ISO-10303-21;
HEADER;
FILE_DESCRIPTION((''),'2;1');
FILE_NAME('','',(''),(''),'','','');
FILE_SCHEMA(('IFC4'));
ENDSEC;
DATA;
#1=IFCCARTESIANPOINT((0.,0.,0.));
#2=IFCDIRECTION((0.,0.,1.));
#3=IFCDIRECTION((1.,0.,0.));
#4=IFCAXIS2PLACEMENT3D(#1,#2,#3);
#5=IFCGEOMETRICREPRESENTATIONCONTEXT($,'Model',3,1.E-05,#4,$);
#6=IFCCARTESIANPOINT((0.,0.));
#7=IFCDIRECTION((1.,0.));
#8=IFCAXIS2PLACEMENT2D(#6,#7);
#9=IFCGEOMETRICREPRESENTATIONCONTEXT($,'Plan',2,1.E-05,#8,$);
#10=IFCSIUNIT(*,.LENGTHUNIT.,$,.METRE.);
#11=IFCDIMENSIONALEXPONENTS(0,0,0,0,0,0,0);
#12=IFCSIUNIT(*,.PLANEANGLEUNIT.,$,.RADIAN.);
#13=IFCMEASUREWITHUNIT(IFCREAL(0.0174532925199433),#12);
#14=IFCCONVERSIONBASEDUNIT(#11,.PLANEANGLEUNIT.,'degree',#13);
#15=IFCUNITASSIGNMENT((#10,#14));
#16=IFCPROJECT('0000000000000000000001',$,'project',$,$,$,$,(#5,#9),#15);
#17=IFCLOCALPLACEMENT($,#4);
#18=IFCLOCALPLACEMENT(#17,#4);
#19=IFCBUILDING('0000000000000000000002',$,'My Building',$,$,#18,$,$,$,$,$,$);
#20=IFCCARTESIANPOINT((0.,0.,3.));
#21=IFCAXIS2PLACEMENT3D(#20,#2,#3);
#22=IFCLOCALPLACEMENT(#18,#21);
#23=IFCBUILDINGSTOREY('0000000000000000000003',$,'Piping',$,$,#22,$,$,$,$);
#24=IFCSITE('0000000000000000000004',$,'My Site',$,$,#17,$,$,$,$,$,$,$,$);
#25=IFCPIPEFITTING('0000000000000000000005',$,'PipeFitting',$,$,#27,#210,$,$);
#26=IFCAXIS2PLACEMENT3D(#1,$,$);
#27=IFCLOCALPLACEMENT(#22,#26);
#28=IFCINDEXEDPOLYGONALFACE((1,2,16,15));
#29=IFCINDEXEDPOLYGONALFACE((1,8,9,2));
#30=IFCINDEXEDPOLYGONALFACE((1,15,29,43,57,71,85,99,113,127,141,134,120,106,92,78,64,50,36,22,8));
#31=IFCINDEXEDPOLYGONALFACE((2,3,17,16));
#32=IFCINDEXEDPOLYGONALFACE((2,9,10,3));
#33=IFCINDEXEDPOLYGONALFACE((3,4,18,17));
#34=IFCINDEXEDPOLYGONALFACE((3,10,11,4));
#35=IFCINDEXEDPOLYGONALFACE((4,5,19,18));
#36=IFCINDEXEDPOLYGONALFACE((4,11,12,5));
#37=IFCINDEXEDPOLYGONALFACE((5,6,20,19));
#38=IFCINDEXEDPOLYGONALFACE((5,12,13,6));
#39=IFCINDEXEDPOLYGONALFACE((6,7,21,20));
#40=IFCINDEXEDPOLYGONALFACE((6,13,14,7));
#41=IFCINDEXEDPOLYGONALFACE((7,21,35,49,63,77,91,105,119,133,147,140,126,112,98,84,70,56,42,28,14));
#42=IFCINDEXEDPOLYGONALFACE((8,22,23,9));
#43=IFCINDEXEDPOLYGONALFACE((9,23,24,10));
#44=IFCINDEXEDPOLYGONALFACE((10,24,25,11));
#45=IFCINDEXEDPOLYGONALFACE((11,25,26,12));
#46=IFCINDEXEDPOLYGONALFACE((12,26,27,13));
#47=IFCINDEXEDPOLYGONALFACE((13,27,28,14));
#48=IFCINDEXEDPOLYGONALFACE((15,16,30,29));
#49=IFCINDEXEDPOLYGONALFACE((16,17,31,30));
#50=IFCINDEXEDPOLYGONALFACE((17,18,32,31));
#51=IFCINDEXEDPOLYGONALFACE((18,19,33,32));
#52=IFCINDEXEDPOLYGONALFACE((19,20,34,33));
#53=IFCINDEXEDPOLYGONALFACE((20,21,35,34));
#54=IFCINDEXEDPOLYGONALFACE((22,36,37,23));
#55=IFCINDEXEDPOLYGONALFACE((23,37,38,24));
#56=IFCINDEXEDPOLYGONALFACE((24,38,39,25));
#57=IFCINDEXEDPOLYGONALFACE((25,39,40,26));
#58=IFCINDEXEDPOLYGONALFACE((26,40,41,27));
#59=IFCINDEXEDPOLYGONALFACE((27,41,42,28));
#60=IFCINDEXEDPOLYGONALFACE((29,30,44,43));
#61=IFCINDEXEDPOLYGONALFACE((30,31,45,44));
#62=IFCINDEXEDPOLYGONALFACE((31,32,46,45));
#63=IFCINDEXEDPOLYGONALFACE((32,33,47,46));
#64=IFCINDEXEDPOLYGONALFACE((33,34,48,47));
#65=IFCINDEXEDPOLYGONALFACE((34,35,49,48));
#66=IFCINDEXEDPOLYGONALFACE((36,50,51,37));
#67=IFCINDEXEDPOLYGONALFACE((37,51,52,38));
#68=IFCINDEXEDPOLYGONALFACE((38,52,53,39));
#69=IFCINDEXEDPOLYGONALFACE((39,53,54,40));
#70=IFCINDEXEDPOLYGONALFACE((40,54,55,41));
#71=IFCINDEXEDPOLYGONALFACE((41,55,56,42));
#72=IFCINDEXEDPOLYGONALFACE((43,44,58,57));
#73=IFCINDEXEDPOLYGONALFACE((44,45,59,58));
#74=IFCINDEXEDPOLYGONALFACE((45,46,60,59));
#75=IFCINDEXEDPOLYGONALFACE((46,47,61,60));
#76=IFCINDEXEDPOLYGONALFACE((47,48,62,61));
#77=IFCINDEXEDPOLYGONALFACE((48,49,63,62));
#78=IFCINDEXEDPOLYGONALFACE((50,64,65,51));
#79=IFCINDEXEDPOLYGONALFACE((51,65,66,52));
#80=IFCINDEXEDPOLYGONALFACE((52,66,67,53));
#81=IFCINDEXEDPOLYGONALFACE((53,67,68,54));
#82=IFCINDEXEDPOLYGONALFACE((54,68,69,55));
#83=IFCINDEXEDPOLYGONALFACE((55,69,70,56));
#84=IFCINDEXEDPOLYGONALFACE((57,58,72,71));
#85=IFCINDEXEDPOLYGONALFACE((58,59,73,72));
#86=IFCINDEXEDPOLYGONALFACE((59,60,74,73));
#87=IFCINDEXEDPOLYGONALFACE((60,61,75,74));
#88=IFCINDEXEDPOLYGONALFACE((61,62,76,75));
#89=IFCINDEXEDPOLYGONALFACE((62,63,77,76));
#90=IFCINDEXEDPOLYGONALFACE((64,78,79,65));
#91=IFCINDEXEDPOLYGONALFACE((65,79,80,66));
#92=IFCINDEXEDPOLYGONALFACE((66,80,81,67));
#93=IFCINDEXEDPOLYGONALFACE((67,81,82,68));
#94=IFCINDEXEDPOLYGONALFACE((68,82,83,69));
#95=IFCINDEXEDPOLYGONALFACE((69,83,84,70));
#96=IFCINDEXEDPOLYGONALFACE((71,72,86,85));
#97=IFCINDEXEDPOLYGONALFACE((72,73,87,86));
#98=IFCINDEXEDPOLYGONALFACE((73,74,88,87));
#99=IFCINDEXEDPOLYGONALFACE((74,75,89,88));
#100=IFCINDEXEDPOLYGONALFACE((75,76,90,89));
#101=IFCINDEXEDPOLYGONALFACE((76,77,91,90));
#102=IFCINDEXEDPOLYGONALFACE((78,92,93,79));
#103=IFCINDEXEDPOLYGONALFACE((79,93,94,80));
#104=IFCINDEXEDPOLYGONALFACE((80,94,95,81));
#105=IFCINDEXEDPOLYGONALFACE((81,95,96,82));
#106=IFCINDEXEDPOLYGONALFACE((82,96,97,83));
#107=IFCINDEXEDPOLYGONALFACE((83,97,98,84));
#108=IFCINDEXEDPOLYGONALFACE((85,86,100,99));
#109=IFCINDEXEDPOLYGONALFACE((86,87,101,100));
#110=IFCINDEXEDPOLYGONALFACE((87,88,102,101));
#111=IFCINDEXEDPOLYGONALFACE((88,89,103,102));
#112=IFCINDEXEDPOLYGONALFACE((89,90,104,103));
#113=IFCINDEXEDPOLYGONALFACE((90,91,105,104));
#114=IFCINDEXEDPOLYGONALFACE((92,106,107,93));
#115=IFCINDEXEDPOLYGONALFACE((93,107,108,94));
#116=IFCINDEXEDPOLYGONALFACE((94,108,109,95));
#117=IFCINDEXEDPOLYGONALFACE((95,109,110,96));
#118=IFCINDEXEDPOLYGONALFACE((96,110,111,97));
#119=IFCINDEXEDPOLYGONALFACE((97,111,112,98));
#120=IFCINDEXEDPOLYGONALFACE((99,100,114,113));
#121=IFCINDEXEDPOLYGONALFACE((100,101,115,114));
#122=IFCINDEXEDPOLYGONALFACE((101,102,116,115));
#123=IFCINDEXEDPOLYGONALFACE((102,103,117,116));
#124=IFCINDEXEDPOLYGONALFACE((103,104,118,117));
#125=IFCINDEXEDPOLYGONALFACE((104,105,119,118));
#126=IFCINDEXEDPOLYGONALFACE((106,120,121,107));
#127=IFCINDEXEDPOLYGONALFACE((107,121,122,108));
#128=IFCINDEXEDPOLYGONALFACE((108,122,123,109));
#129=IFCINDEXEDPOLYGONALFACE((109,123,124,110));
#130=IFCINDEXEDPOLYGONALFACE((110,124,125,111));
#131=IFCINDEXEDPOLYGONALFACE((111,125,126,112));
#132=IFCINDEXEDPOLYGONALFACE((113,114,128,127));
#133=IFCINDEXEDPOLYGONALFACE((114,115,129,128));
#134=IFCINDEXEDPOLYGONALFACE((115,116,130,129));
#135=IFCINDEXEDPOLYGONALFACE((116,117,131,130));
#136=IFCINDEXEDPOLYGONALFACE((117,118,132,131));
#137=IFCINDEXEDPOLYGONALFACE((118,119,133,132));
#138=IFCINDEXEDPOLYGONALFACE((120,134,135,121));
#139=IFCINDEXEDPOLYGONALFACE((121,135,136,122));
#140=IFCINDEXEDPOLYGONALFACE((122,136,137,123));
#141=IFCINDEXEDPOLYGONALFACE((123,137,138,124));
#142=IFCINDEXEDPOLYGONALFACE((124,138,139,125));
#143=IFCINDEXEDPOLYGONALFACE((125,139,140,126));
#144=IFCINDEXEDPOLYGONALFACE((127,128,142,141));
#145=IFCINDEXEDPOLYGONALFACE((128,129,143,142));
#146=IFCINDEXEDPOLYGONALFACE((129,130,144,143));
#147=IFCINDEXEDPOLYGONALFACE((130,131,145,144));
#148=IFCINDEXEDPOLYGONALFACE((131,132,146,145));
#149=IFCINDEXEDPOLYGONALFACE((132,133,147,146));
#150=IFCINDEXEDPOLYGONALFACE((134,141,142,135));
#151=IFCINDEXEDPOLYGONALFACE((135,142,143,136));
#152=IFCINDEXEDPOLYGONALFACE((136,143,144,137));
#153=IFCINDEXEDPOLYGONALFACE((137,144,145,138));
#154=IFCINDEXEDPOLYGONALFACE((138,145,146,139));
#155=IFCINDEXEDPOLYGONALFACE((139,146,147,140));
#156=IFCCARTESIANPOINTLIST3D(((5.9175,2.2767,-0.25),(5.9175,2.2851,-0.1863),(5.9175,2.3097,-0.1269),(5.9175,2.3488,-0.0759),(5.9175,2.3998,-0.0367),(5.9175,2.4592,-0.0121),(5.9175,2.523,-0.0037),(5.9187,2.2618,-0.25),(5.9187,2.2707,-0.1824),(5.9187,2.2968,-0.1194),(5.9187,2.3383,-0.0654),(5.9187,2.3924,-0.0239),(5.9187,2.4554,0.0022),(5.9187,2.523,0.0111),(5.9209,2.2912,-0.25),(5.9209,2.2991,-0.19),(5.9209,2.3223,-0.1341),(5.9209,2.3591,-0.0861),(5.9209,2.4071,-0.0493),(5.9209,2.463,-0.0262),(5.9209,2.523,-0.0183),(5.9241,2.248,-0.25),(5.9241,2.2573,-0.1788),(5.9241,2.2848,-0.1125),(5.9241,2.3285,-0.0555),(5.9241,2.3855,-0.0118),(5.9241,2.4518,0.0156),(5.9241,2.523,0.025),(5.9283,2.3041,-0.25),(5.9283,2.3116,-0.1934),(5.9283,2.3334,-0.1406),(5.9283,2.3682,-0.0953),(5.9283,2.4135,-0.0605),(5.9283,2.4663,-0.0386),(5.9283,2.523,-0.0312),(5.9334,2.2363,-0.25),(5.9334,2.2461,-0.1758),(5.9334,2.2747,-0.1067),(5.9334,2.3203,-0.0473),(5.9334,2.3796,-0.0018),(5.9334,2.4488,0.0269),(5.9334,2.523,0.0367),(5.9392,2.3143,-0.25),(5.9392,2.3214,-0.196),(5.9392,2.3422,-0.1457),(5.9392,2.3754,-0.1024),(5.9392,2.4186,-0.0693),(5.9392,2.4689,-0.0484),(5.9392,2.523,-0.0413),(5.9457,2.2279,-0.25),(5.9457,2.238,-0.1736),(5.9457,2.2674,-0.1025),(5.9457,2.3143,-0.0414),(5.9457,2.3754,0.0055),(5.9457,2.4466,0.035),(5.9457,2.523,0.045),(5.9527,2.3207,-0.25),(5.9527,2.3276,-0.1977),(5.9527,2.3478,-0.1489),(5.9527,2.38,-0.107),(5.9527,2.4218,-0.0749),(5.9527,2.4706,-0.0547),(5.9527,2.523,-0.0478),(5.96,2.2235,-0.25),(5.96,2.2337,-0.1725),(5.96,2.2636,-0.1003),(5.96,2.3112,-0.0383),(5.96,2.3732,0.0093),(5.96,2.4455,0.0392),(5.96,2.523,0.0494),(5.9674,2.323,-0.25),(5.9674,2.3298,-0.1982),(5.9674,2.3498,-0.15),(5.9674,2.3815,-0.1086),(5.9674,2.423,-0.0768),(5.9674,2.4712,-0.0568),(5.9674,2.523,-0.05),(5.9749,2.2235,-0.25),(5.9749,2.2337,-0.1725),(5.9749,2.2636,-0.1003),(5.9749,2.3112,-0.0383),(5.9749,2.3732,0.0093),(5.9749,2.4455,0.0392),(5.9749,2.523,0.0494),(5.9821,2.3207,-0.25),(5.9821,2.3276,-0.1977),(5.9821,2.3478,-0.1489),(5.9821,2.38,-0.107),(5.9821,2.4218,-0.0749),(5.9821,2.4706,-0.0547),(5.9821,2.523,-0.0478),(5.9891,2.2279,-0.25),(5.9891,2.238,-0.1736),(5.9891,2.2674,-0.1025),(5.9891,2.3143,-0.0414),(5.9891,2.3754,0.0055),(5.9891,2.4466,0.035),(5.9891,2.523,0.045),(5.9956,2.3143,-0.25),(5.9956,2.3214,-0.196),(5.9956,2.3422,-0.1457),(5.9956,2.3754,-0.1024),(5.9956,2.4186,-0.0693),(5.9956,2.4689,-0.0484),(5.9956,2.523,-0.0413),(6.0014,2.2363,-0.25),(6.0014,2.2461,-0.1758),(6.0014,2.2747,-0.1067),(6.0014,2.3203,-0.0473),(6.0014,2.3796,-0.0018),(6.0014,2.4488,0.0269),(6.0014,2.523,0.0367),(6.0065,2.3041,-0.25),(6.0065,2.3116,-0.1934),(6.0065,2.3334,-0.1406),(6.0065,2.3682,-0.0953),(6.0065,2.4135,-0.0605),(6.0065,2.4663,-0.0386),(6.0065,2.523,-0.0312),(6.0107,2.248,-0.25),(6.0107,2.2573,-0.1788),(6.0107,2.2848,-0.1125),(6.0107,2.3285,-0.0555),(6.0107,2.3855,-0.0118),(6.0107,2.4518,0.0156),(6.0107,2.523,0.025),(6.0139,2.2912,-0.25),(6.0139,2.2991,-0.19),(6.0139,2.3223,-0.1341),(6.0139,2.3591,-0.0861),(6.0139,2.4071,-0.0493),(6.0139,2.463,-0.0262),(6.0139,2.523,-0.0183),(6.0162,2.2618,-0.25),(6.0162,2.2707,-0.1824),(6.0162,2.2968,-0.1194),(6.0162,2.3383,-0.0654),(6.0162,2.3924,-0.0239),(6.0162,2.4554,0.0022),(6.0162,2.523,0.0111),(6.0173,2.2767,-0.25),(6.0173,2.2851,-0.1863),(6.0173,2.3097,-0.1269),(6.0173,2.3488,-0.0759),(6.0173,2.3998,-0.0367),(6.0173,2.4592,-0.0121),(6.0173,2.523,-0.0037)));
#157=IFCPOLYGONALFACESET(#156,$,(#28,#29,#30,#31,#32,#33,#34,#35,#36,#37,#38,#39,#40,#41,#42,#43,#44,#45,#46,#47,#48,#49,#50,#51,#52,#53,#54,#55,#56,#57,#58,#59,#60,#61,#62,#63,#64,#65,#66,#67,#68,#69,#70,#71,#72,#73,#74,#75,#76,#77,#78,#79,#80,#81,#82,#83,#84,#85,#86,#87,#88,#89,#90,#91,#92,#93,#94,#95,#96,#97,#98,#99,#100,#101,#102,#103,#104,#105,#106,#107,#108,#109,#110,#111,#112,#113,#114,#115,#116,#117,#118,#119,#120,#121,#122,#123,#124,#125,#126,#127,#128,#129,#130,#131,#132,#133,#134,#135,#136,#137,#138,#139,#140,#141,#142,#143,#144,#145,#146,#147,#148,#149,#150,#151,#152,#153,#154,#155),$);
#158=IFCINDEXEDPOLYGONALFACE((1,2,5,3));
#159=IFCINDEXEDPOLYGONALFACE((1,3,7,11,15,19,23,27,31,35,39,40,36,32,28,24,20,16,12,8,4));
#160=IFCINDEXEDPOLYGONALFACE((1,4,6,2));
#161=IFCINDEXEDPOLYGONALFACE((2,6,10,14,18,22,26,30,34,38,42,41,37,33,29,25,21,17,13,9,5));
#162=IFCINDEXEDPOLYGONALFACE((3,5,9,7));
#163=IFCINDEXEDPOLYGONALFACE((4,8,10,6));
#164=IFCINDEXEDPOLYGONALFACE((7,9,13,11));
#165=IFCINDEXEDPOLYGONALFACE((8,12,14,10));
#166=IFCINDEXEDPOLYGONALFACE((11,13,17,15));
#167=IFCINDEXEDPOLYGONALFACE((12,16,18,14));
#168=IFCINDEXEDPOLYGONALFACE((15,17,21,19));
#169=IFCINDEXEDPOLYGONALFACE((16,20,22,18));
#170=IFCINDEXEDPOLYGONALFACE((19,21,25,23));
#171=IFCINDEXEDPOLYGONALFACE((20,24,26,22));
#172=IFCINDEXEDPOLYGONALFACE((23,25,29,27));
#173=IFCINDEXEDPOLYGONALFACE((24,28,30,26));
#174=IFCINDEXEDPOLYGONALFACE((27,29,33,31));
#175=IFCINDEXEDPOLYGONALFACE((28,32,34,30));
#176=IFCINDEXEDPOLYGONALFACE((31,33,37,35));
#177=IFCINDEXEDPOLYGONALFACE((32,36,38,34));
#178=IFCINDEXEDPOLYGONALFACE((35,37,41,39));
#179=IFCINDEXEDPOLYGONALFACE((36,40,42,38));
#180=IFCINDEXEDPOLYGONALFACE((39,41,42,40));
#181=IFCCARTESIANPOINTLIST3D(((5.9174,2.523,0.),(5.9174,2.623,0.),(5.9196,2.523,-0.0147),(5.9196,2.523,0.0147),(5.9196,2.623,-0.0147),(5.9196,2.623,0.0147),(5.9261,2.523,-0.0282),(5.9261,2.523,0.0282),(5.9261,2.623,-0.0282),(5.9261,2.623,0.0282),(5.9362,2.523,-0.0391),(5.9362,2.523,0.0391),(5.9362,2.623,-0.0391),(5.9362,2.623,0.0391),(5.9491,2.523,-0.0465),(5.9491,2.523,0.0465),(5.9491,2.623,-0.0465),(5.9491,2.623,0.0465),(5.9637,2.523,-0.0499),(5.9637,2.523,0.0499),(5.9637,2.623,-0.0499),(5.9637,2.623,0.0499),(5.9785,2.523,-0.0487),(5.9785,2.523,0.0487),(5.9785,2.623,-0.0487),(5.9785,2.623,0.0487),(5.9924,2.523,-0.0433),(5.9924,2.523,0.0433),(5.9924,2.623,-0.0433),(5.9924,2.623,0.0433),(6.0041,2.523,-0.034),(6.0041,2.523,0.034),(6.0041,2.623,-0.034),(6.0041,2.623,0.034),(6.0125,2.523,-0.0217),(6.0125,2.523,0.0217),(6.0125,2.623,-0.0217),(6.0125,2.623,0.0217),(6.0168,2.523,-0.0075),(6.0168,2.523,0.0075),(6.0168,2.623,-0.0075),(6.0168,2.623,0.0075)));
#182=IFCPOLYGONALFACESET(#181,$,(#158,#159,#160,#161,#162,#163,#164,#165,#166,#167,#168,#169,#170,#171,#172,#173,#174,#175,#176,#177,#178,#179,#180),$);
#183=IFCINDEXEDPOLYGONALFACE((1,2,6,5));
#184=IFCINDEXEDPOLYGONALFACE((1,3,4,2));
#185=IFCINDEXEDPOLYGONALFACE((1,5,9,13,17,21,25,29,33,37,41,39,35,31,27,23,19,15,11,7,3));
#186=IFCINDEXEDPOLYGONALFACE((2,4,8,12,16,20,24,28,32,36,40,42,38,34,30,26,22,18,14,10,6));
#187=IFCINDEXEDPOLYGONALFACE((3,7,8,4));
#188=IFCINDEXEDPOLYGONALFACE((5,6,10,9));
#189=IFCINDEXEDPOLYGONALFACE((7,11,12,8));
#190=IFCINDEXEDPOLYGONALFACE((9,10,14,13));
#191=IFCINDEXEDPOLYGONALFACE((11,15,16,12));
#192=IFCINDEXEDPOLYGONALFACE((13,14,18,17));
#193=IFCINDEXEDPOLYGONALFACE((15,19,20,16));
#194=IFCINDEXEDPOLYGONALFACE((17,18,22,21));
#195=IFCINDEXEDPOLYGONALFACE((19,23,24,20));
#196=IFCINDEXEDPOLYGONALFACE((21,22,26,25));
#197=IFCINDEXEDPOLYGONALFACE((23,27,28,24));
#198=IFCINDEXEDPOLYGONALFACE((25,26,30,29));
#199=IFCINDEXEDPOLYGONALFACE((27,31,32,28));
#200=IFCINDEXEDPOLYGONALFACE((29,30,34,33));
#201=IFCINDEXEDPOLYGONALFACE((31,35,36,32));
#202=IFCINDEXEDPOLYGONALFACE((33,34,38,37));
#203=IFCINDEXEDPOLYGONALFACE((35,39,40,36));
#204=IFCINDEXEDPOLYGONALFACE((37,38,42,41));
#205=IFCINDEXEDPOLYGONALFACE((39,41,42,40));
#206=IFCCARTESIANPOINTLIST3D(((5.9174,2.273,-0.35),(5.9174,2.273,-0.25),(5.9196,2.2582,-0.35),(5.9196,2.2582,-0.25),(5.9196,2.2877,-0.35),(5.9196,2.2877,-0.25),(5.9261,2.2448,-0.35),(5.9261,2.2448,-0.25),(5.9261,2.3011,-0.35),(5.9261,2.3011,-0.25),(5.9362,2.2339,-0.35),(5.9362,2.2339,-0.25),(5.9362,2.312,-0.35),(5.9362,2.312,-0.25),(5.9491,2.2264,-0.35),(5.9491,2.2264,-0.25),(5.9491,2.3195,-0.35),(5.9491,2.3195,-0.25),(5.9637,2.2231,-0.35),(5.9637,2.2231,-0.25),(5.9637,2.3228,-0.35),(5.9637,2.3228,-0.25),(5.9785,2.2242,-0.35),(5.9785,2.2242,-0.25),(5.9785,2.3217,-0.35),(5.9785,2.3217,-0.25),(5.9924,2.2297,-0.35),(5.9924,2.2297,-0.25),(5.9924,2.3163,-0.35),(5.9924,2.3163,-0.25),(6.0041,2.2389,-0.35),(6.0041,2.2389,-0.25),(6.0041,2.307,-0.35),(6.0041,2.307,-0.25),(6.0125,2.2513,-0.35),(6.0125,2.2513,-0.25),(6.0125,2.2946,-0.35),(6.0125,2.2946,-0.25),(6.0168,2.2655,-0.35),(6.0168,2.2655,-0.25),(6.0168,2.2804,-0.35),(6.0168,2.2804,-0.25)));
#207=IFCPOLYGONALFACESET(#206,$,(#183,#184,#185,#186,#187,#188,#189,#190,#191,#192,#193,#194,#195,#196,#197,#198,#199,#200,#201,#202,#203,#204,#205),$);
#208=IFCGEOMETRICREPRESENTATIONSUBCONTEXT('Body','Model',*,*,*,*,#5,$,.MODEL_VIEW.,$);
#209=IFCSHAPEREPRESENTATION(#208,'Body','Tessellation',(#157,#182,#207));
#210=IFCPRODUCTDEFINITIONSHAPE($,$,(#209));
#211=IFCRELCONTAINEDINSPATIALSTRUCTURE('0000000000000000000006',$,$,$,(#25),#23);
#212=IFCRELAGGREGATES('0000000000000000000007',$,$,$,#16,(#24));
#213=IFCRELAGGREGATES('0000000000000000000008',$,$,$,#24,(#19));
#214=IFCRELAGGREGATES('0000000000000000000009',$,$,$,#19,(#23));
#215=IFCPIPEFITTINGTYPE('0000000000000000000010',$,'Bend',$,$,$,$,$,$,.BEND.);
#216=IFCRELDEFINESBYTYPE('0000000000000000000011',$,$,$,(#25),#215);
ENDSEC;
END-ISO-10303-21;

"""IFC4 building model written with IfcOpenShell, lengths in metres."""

from ifc_helpers import new_model, entity, si_unit, converted_unit, frame, origin_with_axes, origin_2d_with_axis, place, context, subcontext, project, spatial, circle, extrude, source, transform, mapped, type_object, type_shapes, element, save


model = new_model("IFC4")

# Units and contexts
model_context = context("Model", 3, precision=1e-05, world=origin_with_axes())
plan_context = context("Plan", 2, precision=1e-05, world=origin_2d_with_axis())
body_context = subcontext(model_context, "Body", "Model", "MODEL_VIEW")
ifc_project = project(units=[si_unit("LENGTHUNIT", "METRE"), converted_unit("PLANEANGLEUNIT", "degree", entity("IfcReal", 0.0174532925199433), si_unit("PLANEANGLEUNIT", "RADIAN"), dimensions=[0, 0, 0, 0, 0, 0, 0])], contexts=[model_context, plan_context])

# Site, building, storey
site_placement = place(None, origin_with_axes())
site = spatial("IfcSite", under=ifc_project, at=site_placement, Name="My Site")
building_placement = place(site_placement, origin_with_axes())
building = spatial("IfcBuilding", under=site, at=building_placement, Name="My Building")
storey_placement = place(building_placement, frame((0.0, 0.0, 3.0), z_axis=(0.0, 0.0, 1.0), x_axis=(1.0, 0.0, 0.0)))
storey = spatial("IfcBuildingStorey", under=building, at=storey_placement, Name="Piping")

# Pipe fitting
pipe_fitting_type = type_object("IfcPipeFittingType", Name="Bend", PredefinedType="BEND")
shared_shape = source(origin_with_axes(), body_context, "Body", "SolidModel", [
    entity("IfcSweptDiskSolid", entity("IfcIndexedPolyCurve", entity("IfcCartesianPointList3D", [[0.0, 0.0, -0.1], [0.0, -0.0732, -0.2768], [0.0, -0.25, -0.35]]), [entity("IfcArcIndex", [1, 2, 3])]), 0.05),
    extrude(circle(Radius=0.05), origin_with_axes(), (0.0, 0.0, -1.0), 0.1),
    extrude(circle(Radius=0.05), frame((0.0, -0.25, -0.35), z_axis=(0.0, -1.0, 0.0), x_axis=(1.0, 0.0, 0.0)), (0.0, 0.0, 1.0), 0.1),
])
type_shapes(pipe_fitting_type, [shared_shape])
for number, where, z_axis, x_axis, name in (
    (1, (5.9674, 2.623, 0.0), (0.0, 1.0, 0.0), (-1.0, 0.0, 0.0), "PipeFitting"),
):
    element("IfcPipeFitting", number, at=place(storey_placement, frame(where, z_axis=z_axis, x_axis=x_axis)), inside=storey, type_object=pipe_fitting_type, Name=name, context=body_context, shape_type="MappedRepresentation", body=[
        mapped(shared_shape, transform((0.0, 0.0, 0.0), x_axis=(1.0, 0.0, 0.0), y_axis=(0.0, 1.0, 0.0), z_axis=(0.0, 0.0, 1.0), scale=1.0)),
    ])

save(model, "model.ifc")
